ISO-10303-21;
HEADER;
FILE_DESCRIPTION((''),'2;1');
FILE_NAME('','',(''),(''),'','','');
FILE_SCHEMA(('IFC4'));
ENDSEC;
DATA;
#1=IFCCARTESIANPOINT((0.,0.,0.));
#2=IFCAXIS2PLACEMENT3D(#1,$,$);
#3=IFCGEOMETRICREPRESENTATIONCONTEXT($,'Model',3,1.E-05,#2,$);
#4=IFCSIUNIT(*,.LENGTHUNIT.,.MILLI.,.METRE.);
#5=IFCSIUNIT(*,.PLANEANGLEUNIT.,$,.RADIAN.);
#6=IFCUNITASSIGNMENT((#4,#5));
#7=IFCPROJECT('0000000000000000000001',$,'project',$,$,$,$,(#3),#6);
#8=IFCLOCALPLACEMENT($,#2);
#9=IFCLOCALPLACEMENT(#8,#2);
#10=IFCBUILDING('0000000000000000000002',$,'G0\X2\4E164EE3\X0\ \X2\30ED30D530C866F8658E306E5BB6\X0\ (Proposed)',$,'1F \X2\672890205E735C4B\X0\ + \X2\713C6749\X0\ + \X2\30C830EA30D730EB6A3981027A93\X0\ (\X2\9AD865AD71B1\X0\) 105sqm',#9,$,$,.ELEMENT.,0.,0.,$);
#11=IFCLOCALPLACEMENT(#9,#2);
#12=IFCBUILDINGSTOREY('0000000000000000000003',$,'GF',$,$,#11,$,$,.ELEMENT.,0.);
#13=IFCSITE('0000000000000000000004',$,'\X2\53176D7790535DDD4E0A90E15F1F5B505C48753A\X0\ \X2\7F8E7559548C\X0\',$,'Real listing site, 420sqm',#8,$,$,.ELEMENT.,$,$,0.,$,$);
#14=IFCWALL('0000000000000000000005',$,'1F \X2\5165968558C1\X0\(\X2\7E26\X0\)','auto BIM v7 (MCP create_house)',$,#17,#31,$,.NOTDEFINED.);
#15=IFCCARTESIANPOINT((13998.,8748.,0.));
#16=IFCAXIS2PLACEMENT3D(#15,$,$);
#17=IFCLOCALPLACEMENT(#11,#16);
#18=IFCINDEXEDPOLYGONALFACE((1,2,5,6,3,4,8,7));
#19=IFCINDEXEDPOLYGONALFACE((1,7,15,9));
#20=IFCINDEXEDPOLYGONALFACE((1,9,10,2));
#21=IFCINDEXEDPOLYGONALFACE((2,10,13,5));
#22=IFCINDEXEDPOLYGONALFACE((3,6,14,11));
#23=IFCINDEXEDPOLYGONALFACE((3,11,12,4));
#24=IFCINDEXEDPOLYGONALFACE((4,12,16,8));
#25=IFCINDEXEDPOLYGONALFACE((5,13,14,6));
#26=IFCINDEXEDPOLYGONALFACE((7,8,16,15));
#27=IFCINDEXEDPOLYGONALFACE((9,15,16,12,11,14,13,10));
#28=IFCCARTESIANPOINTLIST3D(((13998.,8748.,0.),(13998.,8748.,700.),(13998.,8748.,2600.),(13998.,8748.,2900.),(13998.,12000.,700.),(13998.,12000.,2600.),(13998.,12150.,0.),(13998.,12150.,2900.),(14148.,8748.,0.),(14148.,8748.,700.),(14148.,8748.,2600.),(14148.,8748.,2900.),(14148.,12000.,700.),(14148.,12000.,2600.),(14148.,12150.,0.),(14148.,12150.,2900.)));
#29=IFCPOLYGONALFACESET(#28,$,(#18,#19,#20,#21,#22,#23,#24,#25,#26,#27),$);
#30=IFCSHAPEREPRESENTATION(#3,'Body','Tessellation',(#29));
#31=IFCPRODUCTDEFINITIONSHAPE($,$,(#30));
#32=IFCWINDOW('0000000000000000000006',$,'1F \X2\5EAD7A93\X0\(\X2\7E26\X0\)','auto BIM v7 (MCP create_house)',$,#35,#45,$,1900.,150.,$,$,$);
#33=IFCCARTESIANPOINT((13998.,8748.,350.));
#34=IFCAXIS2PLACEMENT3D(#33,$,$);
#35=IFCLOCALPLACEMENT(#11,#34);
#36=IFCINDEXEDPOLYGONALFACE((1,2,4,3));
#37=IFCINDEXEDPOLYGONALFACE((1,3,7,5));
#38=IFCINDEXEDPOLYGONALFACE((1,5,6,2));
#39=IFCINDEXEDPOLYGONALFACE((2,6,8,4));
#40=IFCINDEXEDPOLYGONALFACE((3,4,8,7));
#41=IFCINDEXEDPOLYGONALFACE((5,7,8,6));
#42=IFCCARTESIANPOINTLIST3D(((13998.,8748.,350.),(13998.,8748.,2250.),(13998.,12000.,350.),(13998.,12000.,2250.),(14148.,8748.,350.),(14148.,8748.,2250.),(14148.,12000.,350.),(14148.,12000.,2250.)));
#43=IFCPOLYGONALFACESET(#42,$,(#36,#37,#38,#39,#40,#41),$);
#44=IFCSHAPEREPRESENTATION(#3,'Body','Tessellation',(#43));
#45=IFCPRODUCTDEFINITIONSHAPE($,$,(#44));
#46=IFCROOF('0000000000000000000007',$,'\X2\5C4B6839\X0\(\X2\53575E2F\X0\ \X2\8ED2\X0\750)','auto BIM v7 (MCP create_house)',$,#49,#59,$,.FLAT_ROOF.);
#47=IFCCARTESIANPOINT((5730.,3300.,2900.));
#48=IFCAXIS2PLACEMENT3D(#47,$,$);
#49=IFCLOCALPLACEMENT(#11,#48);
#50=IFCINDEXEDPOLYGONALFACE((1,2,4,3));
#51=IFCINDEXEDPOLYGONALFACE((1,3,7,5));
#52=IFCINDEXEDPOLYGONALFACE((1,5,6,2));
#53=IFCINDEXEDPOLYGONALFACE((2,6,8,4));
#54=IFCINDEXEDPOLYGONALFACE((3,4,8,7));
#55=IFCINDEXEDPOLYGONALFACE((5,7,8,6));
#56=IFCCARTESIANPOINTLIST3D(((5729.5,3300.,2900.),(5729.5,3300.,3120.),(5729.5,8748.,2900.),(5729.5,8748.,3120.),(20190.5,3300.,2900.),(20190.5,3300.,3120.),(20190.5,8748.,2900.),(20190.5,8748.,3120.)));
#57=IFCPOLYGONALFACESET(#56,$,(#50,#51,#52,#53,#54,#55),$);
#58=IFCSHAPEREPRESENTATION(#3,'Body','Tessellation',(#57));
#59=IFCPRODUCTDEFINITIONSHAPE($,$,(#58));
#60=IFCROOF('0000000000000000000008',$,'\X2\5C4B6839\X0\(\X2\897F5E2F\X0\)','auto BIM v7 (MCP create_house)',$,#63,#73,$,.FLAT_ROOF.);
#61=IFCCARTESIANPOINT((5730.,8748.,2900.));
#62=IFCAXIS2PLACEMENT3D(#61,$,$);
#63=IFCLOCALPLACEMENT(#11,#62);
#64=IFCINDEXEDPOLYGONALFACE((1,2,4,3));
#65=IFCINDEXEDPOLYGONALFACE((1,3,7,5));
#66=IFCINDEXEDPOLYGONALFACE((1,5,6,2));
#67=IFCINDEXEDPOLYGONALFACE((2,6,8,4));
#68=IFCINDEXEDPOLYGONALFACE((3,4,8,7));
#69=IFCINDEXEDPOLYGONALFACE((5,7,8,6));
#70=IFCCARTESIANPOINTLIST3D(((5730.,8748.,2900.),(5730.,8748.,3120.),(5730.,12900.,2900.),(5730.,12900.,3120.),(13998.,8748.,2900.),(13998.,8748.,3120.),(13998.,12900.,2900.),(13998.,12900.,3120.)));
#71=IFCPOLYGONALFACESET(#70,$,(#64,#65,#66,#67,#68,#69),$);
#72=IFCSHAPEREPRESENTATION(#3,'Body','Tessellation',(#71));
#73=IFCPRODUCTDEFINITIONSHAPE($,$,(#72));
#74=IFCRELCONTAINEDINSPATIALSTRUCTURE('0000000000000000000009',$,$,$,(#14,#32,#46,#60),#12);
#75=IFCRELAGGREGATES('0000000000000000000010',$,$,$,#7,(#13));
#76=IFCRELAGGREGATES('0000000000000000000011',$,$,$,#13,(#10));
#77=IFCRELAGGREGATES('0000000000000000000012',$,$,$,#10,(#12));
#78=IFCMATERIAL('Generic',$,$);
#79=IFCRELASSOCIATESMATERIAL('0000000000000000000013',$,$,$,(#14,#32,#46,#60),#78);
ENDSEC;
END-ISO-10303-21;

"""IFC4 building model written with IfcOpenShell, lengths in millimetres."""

from ifc_helpers import new_model, si_unit, frame, frame_2d, origin, place, context, project, spatial, rectangle, extrude, material, element, fill, save


model = new_model("IFC4")

# Units and contexts
model_context = context("Model", 3, precision=1e-05, world=origin())
ifc_project = project(units=[si_unit("LENGTHUNIT", "METRE", prefix="MILLI"), si_unit("PLANEANGLEUNIT", "RADIAN")], contexts=[model_context])

# Site, building, storey
site_placement = place(None, origin())
site = spatial("IfcSite", under=ifc_project, at=site_placement, Name="北海道川上郡弟子屈町 美留和", ObjectType="Real listing site, 420sqm", CompositionType="ELEMENT", RefElevation=0.0)
building_placement = place(site_placement, origin())
building = spatial("IfcBuilding", under=site, at=building_placement, Name="G0世代 ロフト書斎の家 (Proposed)", ObjectType="1F 木造平屋 + 焼杉 + トリプル樹脂窓 (高断熱) 105sqm", CompositionType="ELEMENT", ElevationOfRefHeight=0.0, ElevationOfTerrain=0.0)
storey_placement = place(building_placement, origin())
storey = spatial("IfcBuildingStorey", under=building, at=storey_placement, Name="GF", CompositionType="ELEMENT", Elevation=0.0)

# Shared definitions
ifc_material = material(Name="Generic")

# Wall, opening, window
wall_1_placement = place(storey_placement, frame((13998.0, 8748.0, 0.0)))
wall_1 = element("IfcWall", 1, at=wall_1_placement, inside=storey, material=ifc_material, Name="1F 入隅壁(縦)", Description="auto BIM v7 (MCP create_house)", PredefinedType="NOTDEFINED", context=model_context, shape_type="SweptSolid", body=[
    extrude(rectangle(XDim=150.0, YDim=3402.0, at=frame_2d((75.0, 1701.0))), frame((13998.0, 8748.0, 0.0)), (0.0, 0.0, 1.0), 2900.0),
])
opening_1_placement = place(storey_placement, frame((13998.0, 8748.0, 350.0)))
opening_1 = element("IfcOpeningElement", 2, at=opening_1_placement, cuts=wall_1, PredefinedType="NOTDEFINED", context=model_context, shape_type="SweptSolid", body=[
    extrude(rectangle(XDim=150.0, YDim=3252.0, at=frame_2d((75.0, 1626.0))), frame((13998.0, 8748.0, 350.0)), (0.0, 0.0, 1.0), 1900.0),
])
window_1_placement = place(storey_placement, frame((13998.0, 8748.0, 350.0)))
window_1 = element("IfcWindow", 3, at=window_1_placement, inside=storey, material=ifc_material, Name="1F 庭窓(縦)", Description="auto BIM v7 (MCP create_house)", OverallHeight=1900.0, OverallWidth=150.0, context=model_context, shape_type="SweptSolid", body=[
    extrude(rectangle(XDim=150.0, YDim=3252.0, at=frame_2d((75.0, 1626.0))), frame((13998.0, 8748.0, 350.0)), (0.0, 0.0, 1.0), 1900.0),
])
fill(opening_1, window_1)

# Roofs
roof_1_placement = place(storey_placement, frame((5730.0, 3300.0, 2900.0)))
element("IfcRoof", 4, at=roof_1_placement, inside=storey, material=ifc_material, Name="屋根(南帯 軒750)", Description="auto BIM v7 (MCP create_house)", PredefinedType="FLAT_ROOF", context=model_context, shape_type="SweptSolid", body=[
    extrude(rectangle(XDim=14461.0, YDim=5448.0, at=frame_2d((7230.0, 2724.0))), frame((5730.0, 3300.0, 2900.0)), (0.0, 0.0, 1.0), 220.0),
])
roof_2_placement = place(storey_placement, frame((5730.0, 8748.0, 2900.0)))
element("IfcRoof", 5, at=roof_2_placement, inside=storey, material=ifc_material, Name="屋根(西帯)", Description="auto BIM v7 (MCP create_house)", PredefinedType="FLAT_ROOF", context=model_context, shape_type="SweptSolid", body=[
    extrude(rectangle(XDim=8268.0, YDim=4152.0, at=frame_2d((4134.0, 2076.0))), frame((5730.0, 8748.0, 2900.0)), (0.0, 0.0, 1.0), 220.0),
])

save(model, "model.ifc")
